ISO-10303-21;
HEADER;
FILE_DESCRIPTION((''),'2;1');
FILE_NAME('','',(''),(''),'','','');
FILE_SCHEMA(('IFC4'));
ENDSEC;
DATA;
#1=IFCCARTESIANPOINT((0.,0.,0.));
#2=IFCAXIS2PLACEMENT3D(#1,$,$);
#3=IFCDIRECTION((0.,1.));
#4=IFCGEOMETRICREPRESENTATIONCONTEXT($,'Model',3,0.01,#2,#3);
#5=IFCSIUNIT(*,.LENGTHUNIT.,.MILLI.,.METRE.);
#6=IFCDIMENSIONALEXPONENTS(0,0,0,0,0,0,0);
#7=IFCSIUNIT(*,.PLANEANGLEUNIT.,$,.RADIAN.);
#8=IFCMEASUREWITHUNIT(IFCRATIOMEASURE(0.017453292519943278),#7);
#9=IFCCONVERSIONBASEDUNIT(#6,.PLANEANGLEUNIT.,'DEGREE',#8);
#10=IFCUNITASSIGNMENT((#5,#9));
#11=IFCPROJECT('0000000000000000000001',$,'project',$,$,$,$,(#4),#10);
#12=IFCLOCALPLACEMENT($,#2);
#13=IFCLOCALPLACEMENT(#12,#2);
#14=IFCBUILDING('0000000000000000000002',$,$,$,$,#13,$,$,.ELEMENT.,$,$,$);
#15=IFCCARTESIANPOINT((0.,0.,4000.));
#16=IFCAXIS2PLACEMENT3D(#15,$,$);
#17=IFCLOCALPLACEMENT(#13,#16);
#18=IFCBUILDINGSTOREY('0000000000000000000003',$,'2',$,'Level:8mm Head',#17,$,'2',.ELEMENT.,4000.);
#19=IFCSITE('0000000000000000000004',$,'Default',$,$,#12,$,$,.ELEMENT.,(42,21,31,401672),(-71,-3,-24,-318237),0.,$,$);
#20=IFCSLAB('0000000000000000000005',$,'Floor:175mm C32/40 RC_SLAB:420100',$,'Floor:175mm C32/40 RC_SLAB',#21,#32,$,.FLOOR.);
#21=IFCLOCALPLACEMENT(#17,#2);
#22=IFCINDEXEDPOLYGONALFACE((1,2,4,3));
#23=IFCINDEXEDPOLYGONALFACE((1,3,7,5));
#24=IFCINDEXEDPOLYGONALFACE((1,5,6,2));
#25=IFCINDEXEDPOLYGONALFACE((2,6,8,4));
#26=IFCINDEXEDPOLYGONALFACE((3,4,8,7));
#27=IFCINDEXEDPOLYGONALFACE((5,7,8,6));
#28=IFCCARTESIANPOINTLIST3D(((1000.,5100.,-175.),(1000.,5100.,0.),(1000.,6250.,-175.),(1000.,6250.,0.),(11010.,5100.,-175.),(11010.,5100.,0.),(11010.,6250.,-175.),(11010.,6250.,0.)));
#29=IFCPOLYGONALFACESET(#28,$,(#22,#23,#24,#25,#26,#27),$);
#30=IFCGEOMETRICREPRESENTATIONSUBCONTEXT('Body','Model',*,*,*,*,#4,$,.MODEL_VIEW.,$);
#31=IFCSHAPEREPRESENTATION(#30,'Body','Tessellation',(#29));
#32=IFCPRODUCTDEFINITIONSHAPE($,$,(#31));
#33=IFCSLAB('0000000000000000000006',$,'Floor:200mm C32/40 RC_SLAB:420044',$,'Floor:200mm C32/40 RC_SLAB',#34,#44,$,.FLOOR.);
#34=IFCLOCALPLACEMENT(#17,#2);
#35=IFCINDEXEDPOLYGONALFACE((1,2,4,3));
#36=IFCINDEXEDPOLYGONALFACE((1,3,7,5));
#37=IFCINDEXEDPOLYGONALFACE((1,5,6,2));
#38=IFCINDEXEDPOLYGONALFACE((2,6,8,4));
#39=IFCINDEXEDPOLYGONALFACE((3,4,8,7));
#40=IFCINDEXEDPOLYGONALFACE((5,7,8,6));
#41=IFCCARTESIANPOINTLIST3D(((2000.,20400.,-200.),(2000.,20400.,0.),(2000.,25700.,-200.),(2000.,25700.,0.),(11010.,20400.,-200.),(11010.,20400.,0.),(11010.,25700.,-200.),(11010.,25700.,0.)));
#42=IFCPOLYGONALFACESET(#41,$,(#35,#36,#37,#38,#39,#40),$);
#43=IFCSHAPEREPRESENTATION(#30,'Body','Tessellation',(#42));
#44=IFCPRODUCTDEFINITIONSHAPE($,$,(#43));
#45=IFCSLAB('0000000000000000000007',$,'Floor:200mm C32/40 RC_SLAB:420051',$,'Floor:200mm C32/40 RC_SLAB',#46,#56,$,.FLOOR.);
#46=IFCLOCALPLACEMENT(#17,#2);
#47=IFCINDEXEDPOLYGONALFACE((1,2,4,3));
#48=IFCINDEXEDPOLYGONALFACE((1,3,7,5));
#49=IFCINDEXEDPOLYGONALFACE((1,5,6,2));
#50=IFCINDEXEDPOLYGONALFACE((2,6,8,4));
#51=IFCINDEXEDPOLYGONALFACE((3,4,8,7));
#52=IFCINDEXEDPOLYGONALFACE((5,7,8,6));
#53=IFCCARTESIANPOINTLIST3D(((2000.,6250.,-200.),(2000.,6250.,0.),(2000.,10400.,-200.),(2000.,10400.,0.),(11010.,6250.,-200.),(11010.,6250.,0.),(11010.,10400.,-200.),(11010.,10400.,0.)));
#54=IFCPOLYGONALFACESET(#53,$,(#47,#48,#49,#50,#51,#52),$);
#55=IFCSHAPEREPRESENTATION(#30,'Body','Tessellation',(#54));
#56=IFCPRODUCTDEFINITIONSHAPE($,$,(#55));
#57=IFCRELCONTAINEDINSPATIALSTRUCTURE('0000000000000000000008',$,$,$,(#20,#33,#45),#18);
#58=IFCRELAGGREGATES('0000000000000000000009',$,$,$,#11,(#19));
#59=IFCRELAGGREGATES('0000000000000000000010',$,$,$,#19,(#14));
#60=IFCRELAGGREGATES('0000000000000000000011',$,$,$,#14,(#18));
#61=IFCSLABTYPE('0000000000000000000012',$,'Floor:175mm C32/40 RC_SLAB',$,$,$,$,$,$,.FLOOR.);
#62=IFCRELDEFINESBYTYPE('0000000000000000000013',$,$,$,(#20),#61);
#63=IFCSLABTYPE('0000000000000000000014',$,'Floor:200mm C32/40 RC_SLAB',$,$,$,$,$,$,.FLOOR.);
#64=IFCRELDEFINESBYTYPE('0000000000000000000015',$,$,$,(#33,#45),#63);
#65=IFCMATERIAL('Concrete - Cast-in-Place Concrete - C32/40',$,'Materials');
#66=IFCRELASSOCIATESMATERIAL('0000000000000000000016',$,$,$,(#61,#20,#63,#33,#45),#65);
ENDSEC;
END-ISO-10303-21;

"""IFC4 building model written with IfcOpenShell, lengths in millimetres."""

from ifc_helpers import new_model, entity, si_unit, converted_unit, direction, frame, origin, place, context, subcontext, project, spatial, indexed_curve, outline, extrude, material, type_object, element, save


model = new_model("IFC4")

# Units and contexts
model_context = context("Model", 3, precision=0.01, world=origin(), true_north=direction((0.0, 1.0)))
body_context = subcontext(model_context, "Body", "Model", "MODEL_VIEW")
ifc_project = project(units=[si_unit("LENGTHUNIT", "METRE", prefix="MILLI"), converted_unit("PLANEANGLEUNIT", "DEGREE", entity("IfcRatioMeasure", 0.017453292519943278), si_unit("PLANEANGLEUNIT", "RADIAN"), dimensions=[0, 0, 0, 0, 0, 0, 0])], contexts=[model_context])

# Site, building, storey
site_placement = place(None, origin())
site = spatial("IfcSite", under=ifc_project, at=site_placement, Name="Default", CompositionType="ELEMENT", RefLatitude=(42, 21, 31, 401672), RefLongitude=(-71, -3, -24, -318237), RefElevation=0.0)
building_placement = place(site_placement, origin())
building = spatial("IfcBuilding", under=site, at=building_placement, CompositionType="ELEMENT")
storey_placement = place(building_placement, frame((0.0, 0.0, 4000.0)))
storey = spatial("IfcBuildingStorey", under=building, at=storey_placement, Name="2", ObjectType="Level:8mm Head", LongName="2", CompositionType="ELEMENT", Elevation=4000.0)

# Shared definitions
ifc_material = material(Name="Concrete - Cast-in-Place Concrete - C32/40", Category="Materials")

# Slabs
slab_type_1 = type_object("IfcSlabType", Name="Floor:175mm C32/40 RC_SLAB", PredefinedType="FLOOR", material=ifc_material)
slab_1_placement = place(storey_placement, origin())
element("IfcSlab", 1, at=slab_1_placement, inside=storey, type_object=slab_type_1, material=ifc_material, Name="Floor:175mm C32/40 RC_SLAB:420100", ObjectType="Floor:175mm C32/40 RC_SLAB", PredefinedType="FLOOR", context=body_context, shape_type="SweptSolid", body=[
    extrude(outline(indexed_curve([(-575.0, -5005.0), (575.0, -5005.0), (575.0, 5005.0), (-575.0, 5005.0), (-575.0, -5005.0)], self_intersect=False)), frame((6005.0, 5675.0, 0.0), z_axis=(0.0, 0.0, -1.0), x_axis=(0.0, 1.0, 0.0)), (0.0, 0.0, 1.0), 175.0),
])
slab_type_2 = type_object("IfcSlabType", Name="Floor:200mm C32/40 RC_SLAB", PredefinedType="FLOOR", material=ifc_material)
slab_2_placement = place(storey_placement, origin())
element("IfcSlab", 2, at=slab_2_placement, inside=storey, type_object=slab_type_2, material=ifc_material, Name="Floor:200mm C32/40 RC_SLAB:420044", ObjectType="Floor:200mm C32/40 RC_SLAB", PredefinedType="FLOOR", context=body_context, shape_type="SweptSolid", body=[
    extrude(outline(indexed_curve([(-2650.0, -4505.0), (2650.0, -4505.0), (2650.0, 4505.0), (-2650.0, 4505.0), (-2650.0, -4505.0)], self_intersect=False)), frame((6505.0, 23050.0, 0.0), z_axis=(0.0, 0.0, -1.0), x_axis=(0.0, 1.0, 0.0)), (0.0, 0.0, 1.0), 200.0),
])
slab_3_placement = place(storey_placement, origin())
element("IfcSlab", 3, at=slab_3_placement, inside=storey, type_object=slab_type_2, material=ifc_material, Name="Floor:200mm C32/40 RC_SLAB:420051", ObjectType="Floor:200mm C32/40 RC_SLAB", PredefinedType="FLOOR", context=body_context, shape_type="SweptSolid", body=[
    extrude(outline(indexed_curve([(-2075.0, -4505.0), (2075.0, -4505.0), (2075.0, 4505.0), (-2075.0, 4505.0), (-2075.0, -4505.0)], self_intersect=False)), frame((6505.0, 8325.0, 0.0), z_axis=(0.0, 0.0, -1.0), x_axis=(0.0, 1.0, 0.0)), (0.0, 0.0, 1.0), 200.0),
])

save(model, "model.ifc")
